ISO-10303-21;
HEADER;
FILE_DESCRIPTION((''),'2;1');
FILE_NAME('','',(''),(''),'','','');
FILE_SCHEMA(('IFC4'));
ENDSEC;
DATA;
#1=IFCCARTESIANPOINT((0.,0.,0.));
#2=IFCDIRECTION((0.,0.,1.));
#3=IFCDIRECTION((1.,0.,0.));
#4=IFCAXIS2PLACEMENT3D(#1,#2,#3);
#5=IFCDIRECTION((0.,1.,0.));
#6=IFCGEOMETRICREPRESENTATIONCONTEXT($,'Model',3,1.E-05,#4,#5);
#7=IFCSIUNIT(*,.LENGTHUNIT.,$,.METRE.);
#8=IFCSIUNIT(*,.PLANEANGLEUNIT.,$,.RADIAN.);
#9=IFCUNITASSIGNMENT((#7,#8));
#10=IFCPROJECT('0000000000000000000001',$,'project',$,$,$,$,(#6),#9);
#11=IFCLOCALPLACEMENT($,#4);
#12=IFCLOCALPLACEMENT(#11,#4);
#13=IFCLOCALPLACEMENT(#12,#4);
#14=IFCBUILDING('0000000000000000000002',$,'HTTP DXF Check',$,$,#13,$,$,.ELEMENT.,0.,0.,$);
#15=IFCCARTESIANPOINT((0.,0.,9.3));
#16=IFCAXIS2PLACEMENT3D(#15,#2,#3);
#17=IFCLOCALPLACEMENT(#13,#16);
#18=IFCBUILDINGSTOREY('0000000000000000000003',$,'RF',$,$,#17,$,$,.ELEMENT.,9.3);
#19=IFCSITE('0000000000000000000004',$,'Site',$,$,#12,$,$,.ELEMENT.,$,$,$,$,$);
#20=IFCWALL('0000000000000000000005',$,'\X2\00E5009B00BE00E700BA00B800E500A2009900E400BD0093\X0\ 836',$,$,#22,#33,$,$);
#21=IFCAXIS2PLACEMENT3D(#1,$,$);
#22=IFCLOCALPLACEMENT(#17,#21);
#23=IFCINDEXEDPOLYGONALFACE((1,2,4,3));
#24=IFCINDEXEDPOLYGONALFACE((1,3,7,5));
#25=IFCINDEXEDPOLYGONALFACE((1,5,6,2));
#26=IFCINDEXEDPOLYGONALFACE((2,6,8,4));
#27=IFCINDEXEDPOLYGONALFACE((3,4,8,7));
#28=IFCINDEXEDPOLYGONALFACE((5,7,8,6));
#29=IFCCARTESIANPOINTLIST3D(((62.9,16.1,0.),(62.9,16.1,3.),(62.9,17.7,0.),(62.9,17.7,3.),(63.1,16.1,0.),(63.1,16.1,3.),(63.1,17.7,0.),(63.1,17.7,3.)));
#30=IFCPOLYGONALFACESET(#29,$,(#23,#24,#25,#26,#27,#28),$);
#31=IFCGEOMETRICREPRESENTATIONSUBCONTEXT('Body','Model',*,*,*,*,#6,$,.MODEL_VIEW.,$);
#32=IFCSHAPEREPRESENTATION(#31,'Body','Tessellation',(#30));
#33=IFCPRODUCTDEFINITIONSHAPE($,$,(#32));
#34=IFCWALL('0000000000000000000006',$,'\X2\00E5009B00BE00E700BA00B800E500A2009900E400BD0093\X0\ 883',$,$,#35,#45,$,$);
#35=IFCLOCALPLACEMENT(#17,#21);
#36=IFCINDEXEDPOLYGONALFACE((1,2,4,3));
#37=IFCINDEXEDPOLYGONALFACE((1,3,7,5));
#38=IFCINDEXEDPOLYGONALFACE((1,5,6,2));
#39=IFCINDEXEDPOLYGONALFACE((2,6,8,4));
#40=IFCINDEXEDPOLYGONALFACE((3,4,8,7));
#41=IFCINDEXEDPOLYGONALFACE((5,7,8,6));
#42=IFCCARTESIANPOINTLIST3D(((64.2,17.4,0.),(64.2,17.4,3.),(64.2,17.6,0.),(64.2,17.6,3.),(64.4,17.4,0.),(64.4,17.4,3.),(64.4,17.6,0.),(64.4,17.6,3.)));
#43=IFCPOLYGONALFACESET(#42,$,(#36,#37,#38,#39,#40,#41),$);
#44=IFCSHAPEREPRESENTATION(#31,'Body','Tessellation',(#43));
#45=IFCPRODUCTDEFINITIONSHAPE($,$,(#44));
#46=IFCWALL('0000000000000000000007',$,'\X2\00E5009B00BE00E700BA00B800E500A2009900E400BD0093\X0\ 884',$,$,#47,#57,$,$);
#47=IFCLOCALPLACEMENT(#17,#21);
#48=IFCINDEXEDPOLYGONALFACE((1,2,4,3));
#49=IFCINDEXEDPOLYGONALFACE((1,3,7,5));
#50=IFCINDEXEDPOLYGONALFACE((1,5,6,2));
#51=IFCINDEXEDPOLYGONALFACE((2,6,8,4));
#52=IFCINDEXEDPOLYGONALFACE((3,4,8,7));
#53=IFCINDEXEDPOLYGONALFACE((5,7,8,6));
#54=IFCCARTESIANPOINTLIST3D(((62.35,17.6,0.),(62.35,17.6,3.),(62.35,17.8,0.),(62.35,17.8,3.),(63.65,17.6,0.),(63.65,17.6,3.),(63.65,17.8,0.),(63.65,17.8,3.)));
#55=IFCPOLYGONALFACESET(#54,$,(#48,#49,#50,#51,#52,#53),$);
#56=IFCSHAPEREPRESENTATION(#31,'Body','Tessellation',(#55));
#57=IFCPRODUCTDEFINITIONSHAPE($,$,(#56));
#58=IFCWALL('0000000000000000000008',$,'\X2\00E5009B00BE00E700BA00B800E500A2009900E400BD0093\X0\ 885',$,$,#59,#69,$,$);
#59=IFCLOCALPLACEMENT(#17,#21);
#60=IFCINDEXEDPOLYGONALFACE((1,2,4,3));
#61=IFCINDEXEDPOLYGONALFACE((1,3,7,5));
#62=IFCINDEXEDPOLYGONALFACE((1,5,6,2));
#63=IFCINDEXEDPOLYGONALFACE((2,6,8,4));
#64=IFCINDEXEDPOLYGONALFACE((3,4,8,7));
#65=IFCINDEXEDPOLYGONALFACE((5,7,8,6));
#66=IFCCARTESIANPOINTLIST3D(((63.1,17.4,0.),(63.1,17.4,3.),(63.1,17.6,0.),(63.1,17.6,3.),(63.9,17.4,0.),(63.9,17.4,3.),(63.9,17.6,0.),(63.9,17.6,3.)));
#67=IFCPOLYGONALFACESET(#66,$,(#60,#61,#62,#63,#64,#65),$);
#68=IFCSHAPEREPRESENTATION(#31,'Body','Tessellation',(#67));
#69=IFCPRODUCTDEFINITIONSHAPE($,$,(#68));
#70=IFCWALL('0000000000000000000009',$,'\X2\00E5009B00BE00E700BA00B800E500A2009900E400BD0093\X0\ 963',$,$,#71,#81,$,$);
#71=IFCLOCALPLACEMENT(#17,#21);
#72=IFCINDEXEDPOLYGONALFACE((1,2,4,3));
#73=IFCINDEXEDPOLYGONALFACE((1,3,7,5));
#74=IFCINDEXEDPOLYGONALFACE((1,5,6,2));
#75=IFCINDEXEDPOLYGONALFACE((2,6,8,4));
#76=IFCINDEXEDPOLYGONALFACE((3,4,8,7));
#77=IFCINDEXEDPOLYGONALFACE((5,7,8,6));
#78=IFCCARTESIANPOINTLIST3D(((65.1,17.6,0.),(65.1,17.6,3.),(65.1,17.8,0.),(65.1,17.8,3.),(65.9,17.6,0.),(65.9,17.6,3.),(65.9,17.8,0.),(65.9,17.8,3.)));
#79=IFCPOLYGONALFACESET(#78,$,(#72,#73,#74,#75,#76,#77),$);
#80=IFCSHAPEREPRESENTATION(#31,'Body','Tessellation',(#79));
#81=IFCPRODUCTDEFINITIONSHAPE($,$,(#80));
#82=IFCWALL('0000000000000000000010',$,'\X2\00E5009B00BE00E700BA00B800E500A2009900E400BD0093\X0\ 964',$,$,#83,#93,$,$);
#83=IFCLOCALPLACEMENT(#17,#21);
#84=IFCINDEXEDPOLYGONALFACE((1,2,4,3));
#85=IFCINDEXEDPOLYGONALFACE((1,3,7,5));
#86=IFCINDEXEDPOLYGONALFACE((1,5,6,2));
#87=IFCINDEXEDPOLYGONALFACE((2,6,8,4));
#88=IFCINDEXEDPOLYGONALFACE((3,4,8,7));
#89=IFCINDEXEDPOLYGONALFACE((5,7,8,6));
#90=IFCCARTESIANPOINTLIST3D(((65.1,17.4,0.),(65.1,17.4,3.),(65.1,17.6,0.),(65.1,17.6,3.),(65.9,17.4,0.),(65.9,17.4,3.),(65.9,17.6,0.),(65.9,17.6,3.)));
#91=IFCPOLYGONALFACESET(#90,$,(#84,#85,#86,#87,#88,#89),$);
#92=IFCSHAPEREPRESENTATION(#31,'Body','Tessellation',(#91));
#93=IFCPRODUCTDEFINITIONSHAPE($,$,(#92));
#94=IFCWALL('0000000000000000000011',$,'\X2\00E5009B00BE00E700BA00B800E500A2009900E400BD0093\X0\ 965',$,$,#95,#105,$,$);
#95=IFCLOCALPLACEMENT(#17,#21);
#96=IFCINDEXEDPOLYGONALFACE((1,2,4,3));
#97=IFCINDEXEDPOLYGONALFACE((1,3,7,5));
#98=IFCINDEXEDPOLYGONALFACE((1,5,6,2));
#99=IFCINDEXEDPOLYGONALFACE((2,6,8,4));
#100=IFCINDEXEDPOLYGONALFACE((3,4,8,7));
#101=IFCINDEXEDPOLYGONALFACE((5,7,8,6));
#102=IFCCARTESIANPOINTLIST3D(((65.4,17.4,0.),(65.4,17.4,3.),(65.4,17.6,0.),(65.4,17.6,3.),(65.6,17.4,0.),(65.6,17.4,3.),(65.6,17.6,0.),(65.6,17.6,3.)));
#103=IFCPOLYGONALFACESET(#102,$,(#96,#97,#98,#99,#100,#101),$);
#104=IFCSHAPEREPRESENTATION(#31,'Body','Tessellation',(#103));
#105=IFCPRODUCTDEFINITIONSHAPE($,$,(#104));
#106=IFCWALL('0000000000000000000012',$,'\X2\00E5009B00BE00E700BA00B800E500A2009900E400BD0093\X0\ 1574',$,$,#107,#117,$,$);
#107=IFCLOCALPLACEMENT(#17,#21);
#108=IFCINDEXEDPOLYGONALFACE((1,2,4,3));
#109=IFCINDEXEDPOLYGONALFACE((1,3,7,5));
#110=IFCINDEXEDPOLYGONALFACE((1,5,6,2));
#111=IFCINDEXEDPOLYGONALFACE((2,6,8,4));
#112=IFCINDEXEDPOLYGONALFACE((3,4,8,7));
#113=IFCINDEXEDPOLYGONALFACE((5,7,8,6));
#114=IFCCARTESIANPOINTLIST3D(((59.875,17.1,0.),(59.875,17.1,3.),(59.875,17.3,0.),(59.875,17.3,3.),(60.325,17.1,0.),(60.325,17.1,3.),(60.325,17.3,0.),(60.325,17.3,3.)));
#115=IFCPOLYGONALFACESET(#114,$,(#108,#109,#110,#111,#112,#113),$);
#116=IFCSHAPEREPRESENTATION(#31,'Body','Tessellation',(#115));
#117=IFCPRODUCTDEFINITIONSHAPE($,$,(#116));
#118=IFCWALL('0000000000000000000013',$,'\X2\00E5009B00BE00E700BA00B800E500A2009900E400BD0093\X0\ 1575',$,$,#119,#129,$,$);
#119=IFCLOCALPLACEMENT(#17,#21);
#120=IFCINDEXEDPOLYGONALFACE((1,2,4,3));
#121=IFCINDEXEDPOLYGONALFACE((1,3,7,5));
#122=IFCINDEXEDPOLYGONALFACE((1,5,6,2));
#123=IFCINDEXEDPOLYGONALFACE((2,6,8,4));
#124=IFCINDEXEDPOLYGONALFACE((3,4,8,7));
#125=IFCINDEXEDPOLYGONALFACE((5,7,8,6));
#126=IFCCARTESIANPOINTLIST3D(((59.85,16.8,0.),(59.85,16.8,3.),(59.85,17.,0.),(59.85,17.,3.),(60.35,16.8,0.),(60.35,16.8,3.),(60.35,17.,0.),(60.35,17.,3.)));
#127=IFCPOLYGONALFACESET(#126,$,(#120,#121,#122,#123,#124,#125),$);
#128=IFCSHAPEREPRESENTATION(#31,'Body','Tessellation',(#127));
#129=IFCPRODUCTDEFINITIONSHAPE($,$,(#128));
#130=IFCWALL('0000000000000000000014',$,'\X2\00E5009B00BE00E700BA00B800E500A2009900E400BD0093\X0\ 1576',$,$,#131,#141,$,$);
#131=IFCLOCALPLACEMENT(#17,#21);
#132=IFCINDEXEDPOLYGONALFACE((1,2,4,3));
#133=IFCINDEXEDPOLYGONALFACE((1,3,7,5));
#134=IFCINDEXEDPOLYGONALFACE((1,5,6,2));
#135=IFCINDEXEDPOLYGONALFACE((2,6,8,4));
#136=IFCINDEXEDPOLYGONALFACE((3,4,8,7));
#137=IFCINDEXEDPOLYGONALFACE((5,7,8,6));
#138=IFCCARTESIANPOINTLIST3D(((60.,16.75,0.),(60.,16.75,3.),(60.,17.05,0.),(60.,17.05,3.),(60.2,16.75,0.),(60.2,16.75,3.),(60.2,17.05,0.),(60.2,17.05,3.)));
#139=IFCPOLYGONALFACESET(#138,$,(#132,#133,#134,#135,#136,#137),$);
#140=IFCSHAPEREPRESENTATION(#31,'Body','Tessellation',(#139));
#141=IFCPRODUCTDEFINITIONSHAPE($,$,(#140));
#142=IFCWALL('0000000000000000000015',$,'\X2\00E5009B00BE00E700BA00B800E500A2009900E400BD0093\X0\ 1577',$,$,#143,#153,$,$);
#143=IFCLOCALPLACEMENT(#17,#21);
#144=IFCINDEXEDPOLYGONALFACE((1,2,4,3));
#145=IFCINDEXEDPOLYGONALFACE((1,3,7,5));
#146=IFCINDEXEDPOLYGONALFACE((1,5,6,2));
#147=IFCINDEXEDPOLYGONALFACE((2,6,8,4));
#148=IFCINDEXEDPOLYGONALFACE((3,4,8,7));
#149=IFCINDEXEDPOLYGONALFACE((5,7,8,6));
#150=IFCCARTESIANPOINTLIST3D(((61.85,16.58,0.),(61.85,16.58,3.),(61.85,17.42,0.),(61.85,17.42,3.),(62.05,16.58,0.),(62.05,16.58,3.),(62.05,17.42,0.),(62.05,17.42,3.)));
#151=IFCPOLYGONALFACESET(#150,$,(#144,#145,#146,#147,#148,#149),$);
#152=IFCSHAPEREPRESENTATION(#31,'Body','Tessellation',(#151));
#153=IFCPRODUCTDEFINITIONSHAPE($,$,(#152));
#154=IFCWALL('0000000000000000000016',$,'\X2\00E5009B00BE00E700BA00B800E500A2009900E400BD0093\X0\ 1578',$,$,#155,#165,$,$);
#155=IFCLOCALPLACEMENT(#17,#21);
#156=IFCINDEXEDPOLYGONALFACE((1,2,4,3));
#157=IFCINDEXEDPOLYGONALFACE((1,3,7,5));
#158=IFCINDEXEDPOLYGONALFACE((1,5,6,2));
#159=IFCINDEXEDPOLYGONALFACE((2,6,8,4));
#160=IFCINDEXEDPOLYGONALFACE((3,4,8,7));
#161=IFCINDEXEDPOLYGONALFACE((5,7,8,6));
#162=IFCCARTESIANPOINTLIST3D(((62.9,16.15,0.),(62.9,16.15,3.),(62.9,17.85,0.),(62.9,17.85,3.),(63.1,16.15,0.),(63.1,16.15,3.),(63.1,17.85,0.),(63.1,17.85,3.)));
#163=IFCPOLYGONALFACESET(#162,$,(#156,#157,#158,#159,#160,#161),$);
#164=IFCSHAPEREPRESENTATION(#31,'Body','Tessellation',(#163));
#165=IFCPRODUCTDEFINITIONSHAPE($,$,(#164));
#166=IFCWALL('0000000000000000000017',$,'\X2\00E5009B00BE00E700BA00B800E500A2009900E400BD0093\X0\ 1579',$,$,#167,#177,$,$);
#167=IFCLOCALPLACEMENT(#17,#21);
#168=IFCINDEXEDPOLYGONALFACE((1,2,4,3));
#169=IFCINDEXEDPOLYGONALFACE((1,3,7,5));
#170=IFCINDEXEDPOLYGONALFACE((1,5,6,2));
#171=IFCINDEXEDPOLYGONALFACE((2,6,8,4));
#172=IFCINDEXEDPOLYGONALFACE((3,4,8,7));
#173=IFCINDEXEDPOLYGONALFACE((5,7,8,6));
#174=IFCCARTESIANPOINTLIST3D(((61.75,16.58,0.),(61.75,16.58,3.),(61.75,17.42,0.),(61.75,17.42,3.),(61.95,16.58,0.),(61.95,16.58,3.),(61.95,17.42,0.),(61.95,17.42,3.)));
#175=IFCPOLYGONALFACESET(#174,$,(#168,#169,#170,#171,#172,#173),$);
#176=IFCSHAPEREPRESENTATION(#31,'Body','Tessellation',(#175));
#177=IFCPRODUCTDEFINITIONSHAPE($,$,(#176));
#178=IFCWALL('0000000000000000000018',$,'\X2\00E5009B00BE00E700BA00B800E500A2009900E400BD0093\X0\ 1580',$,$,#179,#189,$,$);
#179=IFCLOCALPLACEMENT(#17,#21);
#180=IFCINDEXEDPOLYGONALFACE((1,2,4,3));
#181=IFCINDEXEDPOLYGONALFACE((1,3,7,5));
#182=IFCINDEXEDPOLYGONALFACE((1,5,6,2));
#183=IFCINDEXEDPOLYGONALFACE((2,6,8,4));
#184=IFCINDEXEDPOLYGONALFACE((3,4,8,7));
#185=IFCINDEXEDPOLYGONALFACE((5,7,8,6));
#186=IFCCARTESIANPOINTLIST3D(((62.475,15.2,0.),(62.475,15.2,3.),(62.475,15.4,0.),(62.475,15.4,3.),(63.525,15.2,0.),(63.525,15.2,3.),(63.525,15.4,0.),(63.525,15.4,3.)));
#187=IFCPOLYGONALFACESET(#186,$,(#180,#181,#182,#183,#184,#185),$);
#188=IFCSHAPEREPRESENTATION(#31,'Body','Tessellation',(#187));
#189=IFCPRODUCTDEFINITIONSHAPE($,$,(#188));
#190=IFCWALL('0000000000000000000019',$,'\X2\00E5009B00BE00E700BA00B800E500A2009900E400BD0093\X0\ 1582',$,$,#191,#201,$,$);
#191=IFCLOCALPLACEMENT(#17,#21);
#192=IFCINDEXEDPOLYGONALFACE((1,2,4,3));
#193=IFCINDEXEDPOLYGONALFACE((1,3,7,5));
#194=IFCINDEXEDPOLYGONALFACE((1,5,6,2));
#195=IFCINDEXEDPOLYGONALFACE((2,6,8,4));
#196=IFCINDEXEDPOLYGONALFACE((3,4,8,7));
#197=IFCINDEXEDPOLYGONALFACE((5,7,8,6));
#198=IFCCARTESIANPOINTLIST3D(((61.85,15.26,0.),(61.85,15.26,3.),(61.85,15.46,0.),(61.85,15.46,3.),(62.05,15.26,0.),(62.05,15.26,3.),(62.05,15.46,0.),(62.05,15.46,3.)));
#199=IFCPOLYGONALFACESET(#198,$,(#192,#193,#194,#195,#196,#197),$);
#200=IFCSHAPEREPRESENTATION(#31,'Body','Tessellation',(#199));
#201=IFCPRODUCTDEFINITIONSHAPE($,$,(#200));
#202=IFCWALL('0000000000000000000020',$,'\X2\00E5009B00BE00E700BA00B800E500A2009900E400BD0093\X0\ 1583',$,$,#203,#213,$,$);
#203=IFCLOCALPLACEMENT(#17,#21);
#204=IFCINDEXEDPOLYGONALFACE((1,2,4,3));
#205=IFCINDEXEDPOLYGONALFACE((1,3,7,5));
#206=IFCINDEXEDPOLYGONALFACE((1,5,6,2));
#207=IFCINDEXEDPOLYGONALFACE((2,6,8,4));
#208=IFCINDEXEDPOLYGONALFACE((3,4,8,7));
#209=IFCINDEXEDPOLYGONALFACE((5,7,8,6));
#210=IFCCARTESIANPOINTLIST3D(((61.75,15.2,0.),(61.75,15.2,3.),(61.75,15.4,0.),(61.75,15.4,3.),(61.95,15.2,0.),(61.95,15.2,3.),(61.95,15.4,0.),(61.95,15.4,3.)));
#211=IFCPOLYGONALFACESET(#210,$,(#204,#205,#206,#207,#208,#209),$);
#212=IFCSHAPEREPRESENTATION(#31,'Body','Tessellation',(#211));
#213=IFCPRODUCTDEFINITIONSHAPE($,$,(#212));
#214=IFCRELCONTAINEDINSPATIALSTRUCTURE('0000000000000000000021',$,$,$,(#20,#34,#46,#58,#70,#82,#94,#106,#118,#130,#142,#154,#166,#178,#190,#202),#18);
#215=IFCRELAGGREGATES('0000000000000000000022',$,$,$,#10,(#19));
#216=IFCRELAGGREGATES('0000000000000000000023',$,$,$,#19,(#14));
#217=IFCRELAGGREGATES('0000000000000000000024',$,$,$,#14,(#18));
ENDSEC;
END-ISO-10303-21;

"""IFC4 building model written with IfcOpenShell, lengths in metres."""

from ifc_helpers import new_model, si_unit, direction, frame, frame_2d, origin_with_axes, place, context, subcontext, project, spatial, rectangle, extrude, element, save


model = new_model("IFC4")

# Units and contexts
model_context = context("Model", 3, precision=1e-05, world=origin_with_axes(), true_north=direction((0.0, 1.0, 0.0)))
body_context = subcontext(model_context, "Body", "Model", "MODEL_VIEW")
ifc_project = project(units=[si_unit("LENGTHUNIT", "METRE"), si_unit("PLANEANGLEUNIT", "RADIAN")], contexts=[model_context])

# Site, building, storey
placement = place(None, origin_with_axes())
site_placement = place(placement, origin_with_axes())
site = spatial("IfcSite", under=ifc_project, at=site_placement, Name="Site", CompositionType="ELEMENT")
building_placement = place(site_placement, origin_with_axes())
building = spatial("IfcBuilding", under=site, at=building_placement, Name="HTTP DXF Check", CompositionType="ELEMENT", ElevationOfRefHeight=0.0, ElevationOfTerrain=0.0)
storey_placement = place(building_placement, frame((0.0, 0.0, 9.3), z_axis=(0.0, 0.0, 1.0), x_axis=(1.0, 0.0, 0.0)))
storey = spatial("IfcBuildingStorey", under=building, at=storey_placement, Name="RF", CompositionType="ELEMENT", Elevation=9.3)

# Walls
wall_1_placement = place(storey_placement, frame((63.0, 16.9, 0.0), z_axis=(0.0, 0.0, 1.0), x_axis=(0.0, -1.0, 0.0)))
element("IfcWall", 1, at=wall_1_placement, inside=storey, Name="å\u009b¾çº¸å¢\u0099ä½\u0093 836", context=body_context, shape_type="SweptSolid", body=[
    extrude(rectangle(XDim=1.6, YDim=0.2, at=frame_2d((0.0, 0.0), x_axis=(1.0, 0.0, 0.0))), frame((0.0, 0.0, 0.0), z_axis=(0.0, 0.0, 1.0)), (0.0, 0.0, 1.0), 3.0),
])
wall_2_placement = place(storey_placement, frame((64.3, 17.5, 0.0), z_axis=(0.0, 0.0, 1.0), x_axis=(0.0, 1.0, 0.0)))
element("IfcWall", 2, at=wall_2_placement, inside=storey, Name="å\u009b¾çº¸å¢\u0099ä½\u0093 883", context=body_context, shape_type="SweptSolid", body=[
    extrude(rectangle(XDim=0.2, YDim=0.2, at=frame_2d((0.0, 0.0), x_axis=(1.0, 0.0, 0.0))), frame((0.0, 0.0, 0.0), z_axis=(0.0, 0.0, 1.0)), (0.0, 0.0, 1.0), 3.0),
])
wall_3_placement = place(storey_placement, frame((63.0, 17.7, 0.0), z_axis=(0.0, 0.0, 1.0), x_axis=(1.0, 0.0, 0.0)))
element("IfcWall", 3, at=wall_3_placement, inside=storey, Name="å\u009b¾çº¸å¢\u0099ä½\u0093 884", context=body_context, shape_type="SweptSolid", body=[
    extrude(rectangle(XDim=1.3, YDim=0.2, at=frame_2d((0.0, 0.0), x_axis=(1.0, 0.0, 0.0))), frame((0.0, 0.0, 0.0), z_axis=(0.0, 0.0, 1.0)), (0.0, 0.0, 1.0), 3.0),
])
for number, where, z_axis, x_axis, name in (
    (4, (63.5, 17.5, 0.0), (0.0, 0.0, 1.0), (1.0, 0.0, 0.0), "å\u009b¾çº¸å¢\u0099ä½\u0093 885"),
    (5, (65.5, 17.7, 0.0), (0.0, 0.0, 1.0), (1.0, 0.0, 0.0), "å\u009b¾çº¸å¢\u0099ä½\u0093 963"),
    (6, (65.5, 17.5, 0.0), (0.0, 0.0, 1.0), (1.0, 0.0, 0.0), "å\u009b¾çº¸å¢\u0099ä½\u0093 964"),
):
    element("IfcWall", number, at=place(storey_placement, frame(where, z_axis=z_axis, x_axis=x_axis)), inside=storey, Name=name, context=body_context, shape_type="SweptSolid", body=[
        extrude(rectangle(XDim=0.8, YDim=0.2, at=frame_2d((0.0, 0.0), x_axis=(1.0, 0.0, 0.0))), frame((0.0, 0.0, 0.0), z_axis=(0.0, 0.0, 1.0)), (0.0, 0.0, 1.0), 3.0),
    ])
wall_4_placement = place(storey_placement, frame((65.5, 17.5, 0.0), z_axis=(0.0, 0.0, 1.0), x_axis=(0.0, 1.0, 0.0)))
element("IfcWall", 7, at=wall_4_placement, inside=storey, Name="å\u009b¾çº¸å¢\u0099ä½\u0093 965", context=body_context, shape_type="SweptSolid", body=[
    extrude(rectangle(XDim=0.2, YDim=0.2, at=frame_2d((0.0, 0.0), x_axis=(1.0, 0.0, 0.0))), frame((0.0, 0.0, 0.0), z_axis=(0.0, 0.0, 1.0)), (0.0, 0.0, 1.0), 3.0),
])
wall_5_placement = place(storey_placement, frame((60.1, 17.2, 0.0), z_axis=(0.0, 0.0, 1.0), x_axis=(-1.0, 0.0, 0.0)))
element("IfcWall", 8, at=wall_5_placement, inside=storey, Name="å\u009b¾çº¸å¢\u0099ä½\u0093 1574", context=body_context, shape_type="SweptSolid", body=[
    extrude(rectangle(XDim=0.45, YDim=0.2, at=frame_2d((0.0, 0.0), x_axis=(1.0, 0.0, 0.0))), frame((0.0, 0.0, 0.0), z_axis=(0.0, 0.0, 1.0)), (0.0, 0.0, 1.0), 3.0),
])
wall_6_placement = place(storey_placement, frame((60.1, 16.9, 0.0), z_axis=(0.0, 0.0, 1.0), x_axis=(-1.0, 0.0, 0.0)))
element("IfcWall", 9, at=wall_6_placement, inside=storey, Name="å\u009b¾çº¸å¢\u0099ä½\u0093 1575", context=body_context, shape_type="SweptSolid", body=[
    extrude(rectangle(XDim=0.5, YDim=0.2, at=frame_2d((0.0, 0.0), x_axis=(1.0, 0.0, 0.0))), frame((0.0, 0.0, 0.0), z_axis=(0.0, 0.0, 1.0)), (0.0, 0.0, 1.0), 3.0),
])
wall_7_placement = place(storey_placement, frame((60.1, 16.9, 0.0), z_axis=(0.0, 0.0, 1.0), x_axis=(0.0, 1.0, 0.0)))
element("IfcWall", 10, at=wall_7_placement, inside=storey, Name="å\u009b¾çº¸å¢\u0099ä½\u0093 1576", context=body_context, shape_type="SweptSolid", body=[
    extrude(rectangle(XDim=0.3, YDim=0.2, at=frame_2d((0.0, 0.0), x_axis=(1.0, 0.0, 0.0))), frame((0.0, 0.0, 0.0), z_axis=(0.0, 0.0, 1.0)), (0.0, 0.0, 1.0), 3.0),
])
wall_8_placement = place(storey_placement, frame((61.95, 17.0, 0.0), z_axis=(0.0, 0.0, 1.0), x_axis=(0.0, -1.0, 0.0)))
element("IfcWall", 11, at=wall_8_placement, inside=storey, Name="å\u009b¾çº¸å¢\u0099ä½\u0093 1577", context=body_context, shape_type="SweptSolid", body=[
    extrude(rectangle(XDim=0.84, YDim=0.2, at=frame_2d((0.0, 0.0), x_axis=(1.0, 0.0, 0.0))), frame((0.0, 0.0, 0.0), z_axis=(0.0, 0.0, 1.0)), (0.0, 0.0, 1.0), 3.0),
])
wall_9_placement = place(storey_placement, frame((63.0, 17.0, 0.0), z_axis=(0.0, 0.0, 1.0), x_axis=(0.0, -1.0, 0.0)))
element("IfcWall", 12, at=wall_9_placement, inside=storey, Name="å\u009b¾çº¸å¢\u0099ä½\u0093 1578", context=body_context, shape_type="SweptSolid", body=[
    extrude(rectangle(XDim=1.7, YDim=0.2, at=frame_2d((0.0, 0.0), x_axis=(1.0, 0.0, 0.0))), frame((0.0, 0.0, 0.0), z_axis=(0.0, 0.0, 1.0)), (0.0, 0.0, 1.0), 3.0),
])
wall_10_placement = place(storey_placement, frame((61.85, 17.0, 0.0), z_axis=(0.0, 0.0, 1.0), x_axis=(0.0, -1.0, 0.0)))
element("IfcWall", 13, at=wall_10_placement, inside=storey, Name="å\u009b¾çº¸å¢\u0099ä½\u0093 1579", context=body_context, shape_type="SweptSolid", body=[
    extrude(rectangle(XDim=0.84, YDim=0.2, at=frame_2d((0.0, 0.0), x_axis=(1.0, 0.0, 0.0))), frame((0.0, 0.0, 0.0), z_axis=(0.0, 0.0, 1.0)), (0.0, 0.0, 1.0), 3.0),
])
wall_11_placement = place(storey_placement, frame((63.0, 15.3, 0.0), z_axis=(0.0, 0.0, 1.0), x_axis=(-1.0, 0.0, 0.0)))
element("IfcWall", 14, at=wall_11_placement, inside=storey, Name="å\u009b¾çº¸å¢\u0099ä½\u0093 1580", context=body_context, shape_type="SweptSolid", body=[
    extrude(rectangle(XDim=1.05, YDim=0.2, at=frame_2d((0.0, 0.0), x_axis=(1.0, 0.0, 0.0))), frame((0.0, 0.0, 0.0), z_axis=(0.0, 0.0, 1.0)), (0.0, 0.0, 1.0), 3.0),
])
for number, where, z_axis, x_axis, name in (
    (15, (61.95, 15.36, 0.0), (0.0, 0.0, 1.0), (0.0, -1.0, 0.0), "å\u009b¾çº¸å¢\u0099ä½\u0093 1582"),
    (16, (61.85, 15.3, 0.0), (0.0, 0.0, 1.0), (0.0, -1.0, 0.0), "å\u009b¾çº¸å¢\u0099ä½\u0093 1583"),
):
    element("IfcWall", number, at=place(storey_placement, frame(where, z_axis=z_axis, x_axis=x_axis)), inside=storey, Name=name, context=body_context, shape_type="SweptSolid", body=[
        extrude(rectangle(XDim=0.2, YDim=0.2, at=frame_2d((0.0, 0.0), x_axis=(1.0, 0.0, 0.0))), frame((0.0, 0.0, 0.0), z_axis=(0.0, 0.0, 1.0)), (0.0, 0.0, 1.0), 3.0),
    ])

save(model, "model.ifc")
